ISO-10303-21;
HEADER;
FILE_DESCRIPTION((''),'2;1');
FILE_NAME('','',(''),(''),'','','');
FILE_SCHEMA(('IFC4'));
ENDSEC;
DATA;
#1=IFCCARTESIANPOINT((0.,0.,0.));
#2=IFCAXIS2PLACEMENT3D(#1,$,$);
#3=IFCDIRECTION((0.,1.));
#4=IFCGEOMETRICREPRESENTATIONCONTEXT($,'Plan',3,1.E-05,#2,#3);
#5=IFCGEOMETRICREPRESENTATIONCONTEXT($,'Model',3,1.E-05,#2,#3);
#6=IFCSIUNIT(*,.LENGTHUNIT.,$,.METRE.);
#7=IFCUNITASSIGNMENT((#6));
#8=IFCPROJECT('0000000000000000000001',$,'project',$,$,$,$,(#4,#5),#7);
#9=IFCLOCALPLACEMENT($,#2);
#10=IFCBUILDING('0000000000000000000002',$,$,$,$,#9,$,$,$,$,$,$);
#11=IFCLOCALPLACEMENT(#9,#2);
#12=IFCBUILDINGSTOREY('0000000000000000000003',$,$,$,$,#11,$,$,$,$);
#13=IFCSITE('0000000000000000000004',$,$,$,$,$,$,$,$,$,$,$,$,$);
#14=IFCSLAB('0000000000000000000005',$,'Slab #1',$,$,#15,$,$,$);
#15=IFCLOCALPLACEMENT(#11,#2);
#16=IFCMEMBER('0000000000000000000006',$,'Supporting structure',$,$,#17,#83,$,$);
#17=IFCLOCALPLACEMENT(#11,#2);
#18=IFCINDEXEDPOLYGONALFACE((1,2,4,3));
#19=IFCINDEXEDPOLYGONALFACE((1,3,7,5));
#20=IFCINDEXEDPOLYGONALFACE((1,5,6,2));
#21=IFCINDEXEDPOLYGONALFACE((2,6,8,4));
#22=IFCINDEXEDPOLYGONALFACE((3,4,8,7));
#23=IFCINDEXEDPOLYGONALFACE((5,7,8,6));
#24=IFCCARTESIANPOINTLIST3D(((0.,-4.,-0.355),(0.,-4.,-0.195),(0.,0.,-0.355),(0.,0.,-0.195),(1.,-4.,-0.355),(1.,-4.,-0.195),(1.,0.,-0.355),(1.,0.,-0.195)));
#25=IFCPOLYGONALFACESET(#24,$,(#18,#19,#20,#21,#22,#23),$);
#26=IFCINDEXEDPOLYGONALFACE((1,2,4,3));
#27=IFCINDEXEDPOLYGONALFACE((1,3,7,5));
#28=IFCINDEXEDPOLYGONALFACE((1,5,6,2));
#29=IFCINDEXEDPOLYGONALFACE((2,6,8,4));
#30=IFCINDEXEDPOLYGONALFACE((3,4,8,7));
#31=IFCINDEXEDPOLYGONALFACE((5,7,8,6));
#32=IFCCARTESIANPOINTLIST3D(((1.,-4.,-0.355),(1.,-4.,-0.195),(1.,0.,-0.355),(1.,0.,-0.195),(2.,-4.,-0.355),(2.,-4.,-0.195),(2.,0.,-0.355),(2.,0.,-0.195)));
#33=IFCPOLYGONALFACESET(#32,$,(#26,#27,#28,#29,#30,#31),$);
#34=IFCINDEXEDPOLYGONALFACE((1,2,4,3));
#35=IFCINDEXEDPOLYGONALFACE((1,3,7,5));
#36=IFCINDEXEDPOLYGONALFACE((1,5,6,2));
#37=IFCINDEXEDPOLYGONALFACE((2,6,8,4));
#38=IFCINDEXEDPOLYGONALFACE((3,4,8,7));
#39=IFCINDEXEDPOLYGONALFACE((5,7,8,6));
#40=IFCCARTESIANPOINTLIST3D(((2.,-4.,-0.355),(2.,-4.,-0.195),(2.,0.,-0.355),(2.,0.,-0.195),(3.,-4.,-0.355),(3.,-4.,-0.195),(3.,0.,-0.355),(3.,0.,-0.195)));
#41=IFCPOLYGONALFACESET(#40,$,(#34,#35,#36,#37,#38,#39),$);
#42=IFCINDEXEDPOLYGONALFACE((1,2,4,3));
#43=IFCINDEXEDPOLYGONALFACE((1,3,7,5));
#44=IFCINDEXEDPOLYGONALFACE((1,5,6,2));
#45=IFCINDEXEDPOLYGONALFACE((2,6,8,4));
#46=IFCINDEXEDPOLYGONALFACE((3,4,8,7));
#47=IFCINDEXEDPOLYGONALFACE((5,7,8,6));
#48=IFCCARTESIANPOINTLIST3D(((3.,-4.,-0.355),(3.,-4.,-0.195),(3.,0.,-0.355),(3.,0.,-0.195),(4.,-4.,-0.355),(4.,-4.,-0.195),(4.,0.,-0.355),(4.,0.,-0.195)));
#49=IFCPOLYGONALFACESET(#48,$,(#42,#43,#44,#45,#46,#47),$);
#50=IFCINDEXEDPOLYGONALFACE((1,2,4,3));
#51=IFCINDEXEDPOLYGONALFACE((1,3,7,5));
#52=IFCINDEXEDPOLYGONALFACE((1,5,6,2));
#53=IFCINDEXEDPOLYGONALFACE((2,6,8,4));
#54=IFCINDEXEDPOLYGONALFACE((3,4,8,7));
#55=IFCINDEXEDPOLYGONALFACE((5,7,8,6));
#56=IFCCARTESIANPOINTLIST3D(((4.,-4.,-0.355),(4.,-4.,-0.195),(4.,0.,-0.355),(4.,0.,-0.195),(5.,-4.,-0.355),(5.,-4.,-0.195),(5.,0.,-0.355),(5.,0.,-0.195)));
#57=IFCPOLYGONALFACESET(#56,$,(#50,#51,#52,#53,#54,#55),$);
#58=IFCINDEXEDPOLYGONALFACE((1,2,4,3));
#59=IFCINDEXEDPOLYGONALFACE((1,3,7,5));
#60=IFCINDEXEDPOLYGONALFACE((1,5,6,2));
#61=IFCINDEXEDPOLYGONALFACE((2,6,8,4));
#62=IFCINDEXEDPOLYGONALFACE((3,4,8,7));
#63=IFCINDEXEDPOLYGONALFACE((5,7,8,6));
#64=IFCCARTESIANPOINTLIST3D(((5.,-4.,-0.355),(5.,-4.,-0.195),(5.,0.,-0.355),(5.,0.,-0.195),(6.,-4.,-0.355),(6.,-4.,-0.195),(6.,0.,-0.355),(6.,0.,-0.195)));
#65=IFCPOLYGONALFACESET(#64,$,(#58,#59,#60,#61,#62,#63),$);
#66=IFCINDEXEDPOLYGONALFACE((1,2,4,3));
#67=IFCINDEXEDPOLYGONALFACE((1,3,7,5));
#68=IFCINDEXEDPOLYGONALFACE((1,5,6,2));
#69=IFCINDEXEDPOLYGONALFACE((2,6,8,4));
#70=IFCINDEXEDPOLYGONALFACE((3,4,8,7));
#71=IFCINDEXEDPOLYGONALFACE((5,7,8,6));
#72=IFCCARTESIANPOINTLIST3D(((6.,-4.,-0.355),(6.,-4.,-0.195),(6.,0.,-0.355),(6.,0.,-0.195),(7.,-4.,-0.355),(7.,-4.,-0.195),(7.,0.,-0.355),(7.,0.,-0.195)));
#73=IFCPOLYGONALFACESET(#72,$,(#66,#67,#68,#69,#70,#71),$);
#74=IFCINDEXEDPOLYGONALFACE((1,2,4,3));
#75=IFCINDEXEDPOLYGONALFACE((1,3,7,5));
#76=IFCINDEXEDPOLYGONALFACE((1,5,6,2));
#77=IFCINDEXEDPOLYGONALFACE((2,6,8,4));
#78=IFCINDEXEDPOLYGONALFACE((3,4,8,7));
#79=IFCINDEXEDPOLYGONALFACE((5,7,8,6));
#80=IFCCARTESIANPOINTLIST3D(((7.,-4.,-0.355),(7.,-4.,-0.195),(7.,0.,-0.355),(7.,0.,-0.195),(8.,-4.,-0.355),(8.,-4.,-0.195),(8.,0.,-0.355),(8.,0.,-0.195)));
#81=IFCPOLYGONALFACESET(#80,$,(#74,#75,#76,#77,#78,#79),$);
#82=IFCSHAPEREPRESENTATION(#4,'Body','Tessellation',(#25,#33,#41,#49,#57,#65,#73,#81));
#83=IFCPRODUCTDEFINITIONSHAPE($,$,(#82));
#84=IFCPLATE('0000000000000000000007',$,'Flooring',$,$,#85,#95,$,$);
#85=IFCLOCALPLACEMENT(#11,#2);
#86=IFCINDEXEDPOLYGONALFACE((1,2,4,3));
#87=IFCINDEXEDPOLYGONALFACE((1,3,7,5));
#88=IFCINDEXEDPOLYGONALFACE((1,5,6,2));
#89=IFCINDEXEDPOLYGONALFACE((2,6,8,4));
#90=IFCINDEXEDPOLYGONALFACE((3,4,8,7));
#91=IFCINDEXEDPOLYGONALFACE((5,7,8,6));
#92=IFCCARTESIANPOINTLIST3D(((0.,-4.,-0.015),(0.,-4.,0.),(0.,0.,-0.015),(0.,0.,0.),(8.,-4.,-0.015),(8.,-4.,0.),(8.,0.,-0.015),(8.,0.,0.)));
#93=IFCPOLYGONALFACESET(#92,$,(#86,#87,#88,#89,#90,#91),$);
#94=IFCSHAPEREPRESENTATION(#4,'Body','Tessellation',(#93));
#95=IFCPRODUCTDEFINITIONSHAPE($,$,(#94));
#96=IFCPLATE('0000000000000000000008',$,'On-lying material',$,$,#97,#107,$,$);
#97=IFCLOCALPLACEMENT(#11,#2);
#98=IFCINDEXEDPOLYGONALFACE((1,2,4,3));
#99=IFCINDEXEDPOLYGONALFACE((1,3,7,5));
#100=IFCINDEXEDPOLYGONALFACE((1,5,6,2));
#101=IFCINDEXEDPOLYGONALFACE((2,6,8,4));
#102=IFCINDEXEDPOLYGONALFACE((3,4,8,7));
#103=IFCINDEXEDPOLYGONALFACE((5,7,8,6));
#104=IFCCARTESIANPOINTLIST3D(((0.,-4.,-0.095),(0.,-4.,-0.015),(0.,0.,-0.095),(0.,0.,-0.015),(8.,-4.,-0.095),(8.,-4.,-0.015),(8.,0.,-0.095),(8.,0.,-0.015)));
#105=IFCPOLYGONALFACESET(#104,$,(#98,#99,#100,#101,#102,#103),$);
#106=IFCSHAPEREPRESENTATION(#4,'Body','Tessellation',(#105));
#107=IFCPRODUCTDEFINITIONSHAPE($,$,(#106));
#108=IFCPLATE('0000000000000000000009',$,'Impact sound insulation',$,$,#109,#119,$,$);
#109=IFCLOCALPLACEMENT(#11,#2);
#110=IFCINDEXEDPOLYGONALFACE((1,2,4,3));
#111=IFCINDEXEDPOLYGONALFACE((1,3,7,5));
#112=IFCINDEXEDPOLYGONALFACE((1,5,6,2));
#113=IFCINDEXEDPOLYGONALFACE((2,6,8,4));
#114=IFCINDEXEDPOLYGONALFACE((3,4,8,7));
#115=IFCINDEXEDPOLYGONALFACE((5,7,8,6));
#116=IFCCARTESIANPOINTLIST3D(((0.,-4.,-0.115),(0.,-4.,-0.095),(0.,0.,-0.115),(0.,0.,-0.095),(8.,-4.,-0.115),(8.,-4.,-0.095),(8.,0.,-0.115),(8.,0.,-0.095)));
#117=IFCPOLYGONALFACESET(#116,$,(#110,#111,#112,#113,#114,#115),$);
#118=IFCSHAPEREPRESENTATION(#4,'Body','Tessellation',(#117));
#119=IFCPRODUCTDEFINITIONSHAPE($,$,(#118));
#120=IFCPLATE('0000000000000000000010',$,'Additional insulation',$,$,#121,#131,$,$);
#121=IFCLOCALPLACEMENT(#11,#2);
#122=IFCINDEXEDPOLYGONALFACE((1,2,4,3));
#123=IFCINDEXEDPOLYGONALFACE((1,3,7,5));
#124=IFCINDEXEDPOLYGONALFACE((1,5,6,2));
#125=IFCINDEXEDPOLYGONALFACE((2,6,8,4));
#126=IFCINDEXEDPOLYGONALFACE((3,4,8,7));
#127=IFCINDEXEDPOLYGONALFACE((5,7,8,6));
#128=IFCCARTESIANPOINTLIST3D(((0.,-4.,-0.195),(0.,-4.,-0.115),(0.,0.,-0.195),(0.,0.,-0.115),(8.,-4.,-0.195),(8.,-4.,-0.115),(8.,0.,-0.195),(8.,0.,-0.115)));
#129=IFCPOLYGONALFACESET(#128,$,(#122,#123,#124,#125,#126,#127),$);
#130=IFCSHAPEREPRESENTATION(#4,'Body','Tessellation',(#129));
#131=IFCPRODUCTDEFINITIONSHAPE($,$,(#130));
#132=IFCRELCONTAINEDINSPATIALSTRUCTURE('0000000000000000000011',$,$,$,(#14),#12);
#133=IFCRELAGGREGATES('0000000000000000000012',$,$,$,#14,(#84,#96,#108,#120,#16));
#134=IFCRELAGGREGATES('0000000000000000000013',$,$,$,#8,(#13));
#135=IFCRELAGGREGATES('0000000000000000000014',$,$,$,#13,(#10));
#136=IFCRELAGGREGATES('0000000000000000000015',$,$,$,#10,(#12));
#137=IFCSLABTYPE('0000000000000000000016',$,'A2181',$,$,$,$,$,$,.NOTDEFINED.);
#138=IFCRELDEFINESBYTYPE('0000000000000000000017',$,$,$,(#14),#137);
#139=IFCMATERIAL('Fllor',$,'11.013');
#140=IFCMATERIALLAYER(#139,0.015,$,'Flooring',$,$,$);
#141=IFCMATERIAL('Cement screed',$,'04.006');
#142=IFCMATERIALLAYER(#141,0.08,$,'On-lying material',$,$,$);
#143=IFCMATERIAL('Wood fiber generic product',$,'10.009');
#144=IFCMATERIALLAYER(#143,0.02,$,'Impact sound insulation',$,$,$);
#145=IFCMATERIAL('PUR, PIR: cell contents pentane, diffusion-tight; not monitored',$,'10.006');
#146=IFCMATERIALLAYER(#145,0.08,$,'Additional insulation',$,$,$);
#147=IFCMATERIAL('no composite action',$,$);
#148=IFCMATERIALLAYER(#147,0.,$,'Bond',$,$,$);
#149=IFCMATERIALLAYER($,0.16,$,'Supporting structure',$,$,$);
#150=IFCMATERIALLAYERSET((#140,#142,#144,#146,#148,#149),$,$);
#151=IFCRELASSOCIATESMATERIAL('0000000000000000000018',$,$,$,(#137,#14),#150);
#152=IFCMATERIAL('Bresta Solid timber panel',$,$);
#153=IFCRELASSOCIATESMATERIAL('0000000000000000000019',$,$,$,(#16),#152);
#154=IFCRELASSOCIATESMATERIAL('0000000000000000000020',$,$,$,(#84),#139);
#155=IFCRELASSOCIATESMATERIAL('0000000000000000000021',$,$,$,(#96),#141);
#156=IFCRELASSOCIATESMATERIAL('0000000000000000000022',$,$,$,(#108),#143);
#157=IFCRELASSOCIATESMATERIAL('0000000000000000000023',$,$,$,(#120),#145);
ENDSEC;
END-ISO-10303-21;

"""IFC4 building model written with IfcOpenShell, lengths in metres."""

from ifc_helpers import new_model, si_unit, direction, frame, frame_2d, origin, origin_with_axes, place, context, project, spatial, rectangle, extrude, material, layer, layer_set, type_object, element, aggregate, save


model = new_model("IFC4")

# Units and contexts
plan_context = context("Plan", 3, precision=1e-05, world=origin(), true_north=direction((0.0, 1.0)))
model_context = context("Model", 3, precision=1e-05, world=origin(), true_north=direction((0.0, 1.0)))
ifc_project = project(units=[si_unit("LENGTHUNIT", "METRE")], contexts=[plan_context, model_context])

# Site, building, storey
site = spatial("IfcSite", under=ifc_project)
building_placement = place(None, origin())
building = spatial("IfcBuilding", under=site, at=building_placement)
storey_placement = place(building_placement, origin())
storey = spatial("IfcBuildingStorey", under=building, at=storey_placement)

# Slab, member, plates
ifc_material_1 = material(Name="Fllor", Category="11.013")
ifc_layer_1 = layer(ifc_material_1, 0.015, Name="Flooring")
ifc_material_2 = material(Name="Cement screed", Category="04.006")
ifc_layer_2 = layer(ifc_material_2, 0.08, Name="On-lying material")
ifc_material_3 = material(Name="Wood fiber generic product", Category="10.009")
ifc_layer_3 = layer(ifc_material_3, 0.02, Name="Impact sound insulation")
ifc_material_4 = material(Name="PUR, PIR: cell contents pentane, diffusion-tight; not monitored", Category="10.006")
ifc_layer_4 = layer(ifc_material_4, 0.08, Name="Additional insulation")
ifc_material_5 = material(Name="no composite action")
ifc_layer_5 = layer(ifc_material_5, 0.0, Name="Bond")
ifc_layer_6 = layer(None, 0.16, Name="Supporting structure")
ifc_layer_set = layer_set([ifc_layer_1, ifc_layer_2, ifc_layer_3, ifc_layer_4, ifc_layer_5, ifc_layer_6])
slab_type = type_object("IfcSlabType", Name="A2181", PredefinedType="NOTDEFINED", material=ifc_layer_set)
slab_placement = place(None, frame((0.0, 0.0, 0.0), z_axis=(0.0, 0.0, -1.0), x_axis=(1.0, 0.0, 0.0)))
slab = element("IfcSlab", 1, at=slab_placement, inside=storey, type_object=slab_type, material=ifc_layer_set, Name="Slab #1")
ifc_material_6 = material(Name="Bresta Solid timber panel")
member_placement = place(slab_placement, origin())
member = element("IfcMember", 2, at=member_placement, material=ifc_material_6, Name="Supporting structure", context=plan_context, shape_type="SweptSolid", body=[
    extrude(rectangle(XDim=1.0, YDim=0.16, at=frame_2d((0.5, 0.08), x_axis=(1.0, 0.0))), frame((0.0, 4.0, 0.195), z_axis=(0.0, -1.0, 0.0), x_axis=(1.0, 0.0, 0.0)), (0.0, 0.0, 1.0), 4.0),
    extrude(rectangle(XDim=1.0, YDim=0.16, at=frame_2d((0.5, 0.08), x_axis=(1.0, 0.0))), frame((1.0, 4.0, 0.195), z_axis=(0.0, -1.0, 0.0), x_axis=(1.0, 0.0, 0.0)), (0.0, 0.0, 1.0), 4.0),
    extrude(rectangle(XDim=1.0, YDim=0.16, at=frame_2d((0.5, 0.08), x_axis=(1.0, 0.0))), frame((2.0, 4.0, 0.195), z_axis=(0.0, -1.0, 0.0), x_axis=(1.0, 0.0, 0.0)), (0.0, 0.0, 1.0), 4.0),
    extrude(rectangle(XDim=1.0, YDim=0.16, at=frame_2d((0.5, 0.08), x_axis=(1.0, 0.0))), frame((3.0, 4.0, 0.195), z_axis=(0.0, -1.0, 0.0), x_axis=(1.0, 0.0, 0.0)), (0.0, 0.0, 1.0), 4.0),
    extrude(rectangle(XDim=1.0, YDim=0.16, at=frame_2d((0.5, 0.08), x_axis=(1.0, 0.0))), frame((4.0, 4.0, 0.195), z_axis=(0.0, -1.0, 0.0), x_axis=(1.0, 0.0, 0.0)), (0.0, 0.0, 1.0), 4.0),
    extrude(rectangle(XDim=1.0, YDim=0.16, at=frame_2d((0.5, 0.08), x_axis=(1.0, 0.0))), frame((5.0, 4.0, 0.195), z_axis=(0.0, -1.0, 0.0), x_axis=(1.0, 0.0, 0.0)), (0.0, 0.0, 1.0), 4.0),
    extrude(rectangle(XDim=1.0, YDim=0.16, at=frame_2d((0.5, 0.08), x_axis=(1.0, 0.0))), frame((6.0, 4.0, 0.195), z_axis=(0.0, -1.0, 0.0), x_axis=(1.0, 0.0, 0.0)), (0.0, 0.0, 1.0), 4.0),
    extrude(rectangle(XDim=1.0, YDim=0.16, at=frame_2d((0.5, 0.08), x_axis=(1.0, 0.0))), frame((7.0, 4.0, 0.195), z_axis=(0.0, -1.0, 0.0), x_axis=(1.0, 0.0, 0.0)), (0.0, 0.0, 1.0), 4.0),
])
plate_1_placement = place(slab_placement, origin())
plate_1 = element("IfcPlate", 3, at=plate_1_placement, material=ifc_material_1, Name="Flooring", context=plan_context, shape_type="SweptSolid", body=[
    extrude(rectangle(XDim=8.0, YDim=4.0, at=frame_2d((4.0, 2.0), x_axis=(1.0, 0.0))), origin_with_axes(), (0.0, 0.0, 1.0), 0.015),
])
plate_2_placement = place(slab_placement, origin())
plate_2 = element("IfcPlate", 4, at=plate_2_placement, material=ifc_material_2, Name="On-lying material", context=plan_context, shape_type="SweptSolid", body=[
    extrude(rectangle(XDim=8.0, YDim=4.0, at=frame_2d((4.0, 2.0), x_axis=(1.0, 0.0))), frame((0.0, 0.0, 0.015), z_axis=(0.0, 0.0, 1.0), x_axis=(1.0, 0.0, 0.0)), (0.0, 0.0, 1.0), 0.08),
])
plate_3_placement = place(slab_placement, origin())
plate_3 = element("IfcPlate", 5, at=plate_3_placement, material=ifc_material_3, Name="Impact sound insulation", context=plan_context, shape_type="SweptSolid", body=[
    extrude(rectangle(XDim=8.0, YDim=4.0, at=frame_2d((4.0, 2.0), x_axis=(1.0, 0.0))), frame((0.0, 0.0, 0.095), z_axis=(0.0, 0.0, 1.0), x_axis=(1.0, 0.0, 0.0)), (0.0, 0.0, 1.0), 0.02),
])
plate_4_placement = place(slab_placement, origin())
plate_4 = element("IfcPlate", 6, at=plate_4_placement, material=ifc_material_4, Name="Additional insulation", context=plan_context, shape_type="SweptSolid", body=[
    extrude(rectangle(XDim=8.0, YDim=4.0, at=frame_2d((4.0, 2.0), x_axis=(1.0, 0.0))), frame((0.0, 0.0, 0.115), z_axis=(0.0, 0.0, 1.0), x_axis=(1.0, 0.0, 0.0)), (0.0, 0.0, 1.0), 0.08),
])
aggregate(slab, [plate_1, plate_2, plate_3, plate_4, member])

save(model, "model.ifc")
